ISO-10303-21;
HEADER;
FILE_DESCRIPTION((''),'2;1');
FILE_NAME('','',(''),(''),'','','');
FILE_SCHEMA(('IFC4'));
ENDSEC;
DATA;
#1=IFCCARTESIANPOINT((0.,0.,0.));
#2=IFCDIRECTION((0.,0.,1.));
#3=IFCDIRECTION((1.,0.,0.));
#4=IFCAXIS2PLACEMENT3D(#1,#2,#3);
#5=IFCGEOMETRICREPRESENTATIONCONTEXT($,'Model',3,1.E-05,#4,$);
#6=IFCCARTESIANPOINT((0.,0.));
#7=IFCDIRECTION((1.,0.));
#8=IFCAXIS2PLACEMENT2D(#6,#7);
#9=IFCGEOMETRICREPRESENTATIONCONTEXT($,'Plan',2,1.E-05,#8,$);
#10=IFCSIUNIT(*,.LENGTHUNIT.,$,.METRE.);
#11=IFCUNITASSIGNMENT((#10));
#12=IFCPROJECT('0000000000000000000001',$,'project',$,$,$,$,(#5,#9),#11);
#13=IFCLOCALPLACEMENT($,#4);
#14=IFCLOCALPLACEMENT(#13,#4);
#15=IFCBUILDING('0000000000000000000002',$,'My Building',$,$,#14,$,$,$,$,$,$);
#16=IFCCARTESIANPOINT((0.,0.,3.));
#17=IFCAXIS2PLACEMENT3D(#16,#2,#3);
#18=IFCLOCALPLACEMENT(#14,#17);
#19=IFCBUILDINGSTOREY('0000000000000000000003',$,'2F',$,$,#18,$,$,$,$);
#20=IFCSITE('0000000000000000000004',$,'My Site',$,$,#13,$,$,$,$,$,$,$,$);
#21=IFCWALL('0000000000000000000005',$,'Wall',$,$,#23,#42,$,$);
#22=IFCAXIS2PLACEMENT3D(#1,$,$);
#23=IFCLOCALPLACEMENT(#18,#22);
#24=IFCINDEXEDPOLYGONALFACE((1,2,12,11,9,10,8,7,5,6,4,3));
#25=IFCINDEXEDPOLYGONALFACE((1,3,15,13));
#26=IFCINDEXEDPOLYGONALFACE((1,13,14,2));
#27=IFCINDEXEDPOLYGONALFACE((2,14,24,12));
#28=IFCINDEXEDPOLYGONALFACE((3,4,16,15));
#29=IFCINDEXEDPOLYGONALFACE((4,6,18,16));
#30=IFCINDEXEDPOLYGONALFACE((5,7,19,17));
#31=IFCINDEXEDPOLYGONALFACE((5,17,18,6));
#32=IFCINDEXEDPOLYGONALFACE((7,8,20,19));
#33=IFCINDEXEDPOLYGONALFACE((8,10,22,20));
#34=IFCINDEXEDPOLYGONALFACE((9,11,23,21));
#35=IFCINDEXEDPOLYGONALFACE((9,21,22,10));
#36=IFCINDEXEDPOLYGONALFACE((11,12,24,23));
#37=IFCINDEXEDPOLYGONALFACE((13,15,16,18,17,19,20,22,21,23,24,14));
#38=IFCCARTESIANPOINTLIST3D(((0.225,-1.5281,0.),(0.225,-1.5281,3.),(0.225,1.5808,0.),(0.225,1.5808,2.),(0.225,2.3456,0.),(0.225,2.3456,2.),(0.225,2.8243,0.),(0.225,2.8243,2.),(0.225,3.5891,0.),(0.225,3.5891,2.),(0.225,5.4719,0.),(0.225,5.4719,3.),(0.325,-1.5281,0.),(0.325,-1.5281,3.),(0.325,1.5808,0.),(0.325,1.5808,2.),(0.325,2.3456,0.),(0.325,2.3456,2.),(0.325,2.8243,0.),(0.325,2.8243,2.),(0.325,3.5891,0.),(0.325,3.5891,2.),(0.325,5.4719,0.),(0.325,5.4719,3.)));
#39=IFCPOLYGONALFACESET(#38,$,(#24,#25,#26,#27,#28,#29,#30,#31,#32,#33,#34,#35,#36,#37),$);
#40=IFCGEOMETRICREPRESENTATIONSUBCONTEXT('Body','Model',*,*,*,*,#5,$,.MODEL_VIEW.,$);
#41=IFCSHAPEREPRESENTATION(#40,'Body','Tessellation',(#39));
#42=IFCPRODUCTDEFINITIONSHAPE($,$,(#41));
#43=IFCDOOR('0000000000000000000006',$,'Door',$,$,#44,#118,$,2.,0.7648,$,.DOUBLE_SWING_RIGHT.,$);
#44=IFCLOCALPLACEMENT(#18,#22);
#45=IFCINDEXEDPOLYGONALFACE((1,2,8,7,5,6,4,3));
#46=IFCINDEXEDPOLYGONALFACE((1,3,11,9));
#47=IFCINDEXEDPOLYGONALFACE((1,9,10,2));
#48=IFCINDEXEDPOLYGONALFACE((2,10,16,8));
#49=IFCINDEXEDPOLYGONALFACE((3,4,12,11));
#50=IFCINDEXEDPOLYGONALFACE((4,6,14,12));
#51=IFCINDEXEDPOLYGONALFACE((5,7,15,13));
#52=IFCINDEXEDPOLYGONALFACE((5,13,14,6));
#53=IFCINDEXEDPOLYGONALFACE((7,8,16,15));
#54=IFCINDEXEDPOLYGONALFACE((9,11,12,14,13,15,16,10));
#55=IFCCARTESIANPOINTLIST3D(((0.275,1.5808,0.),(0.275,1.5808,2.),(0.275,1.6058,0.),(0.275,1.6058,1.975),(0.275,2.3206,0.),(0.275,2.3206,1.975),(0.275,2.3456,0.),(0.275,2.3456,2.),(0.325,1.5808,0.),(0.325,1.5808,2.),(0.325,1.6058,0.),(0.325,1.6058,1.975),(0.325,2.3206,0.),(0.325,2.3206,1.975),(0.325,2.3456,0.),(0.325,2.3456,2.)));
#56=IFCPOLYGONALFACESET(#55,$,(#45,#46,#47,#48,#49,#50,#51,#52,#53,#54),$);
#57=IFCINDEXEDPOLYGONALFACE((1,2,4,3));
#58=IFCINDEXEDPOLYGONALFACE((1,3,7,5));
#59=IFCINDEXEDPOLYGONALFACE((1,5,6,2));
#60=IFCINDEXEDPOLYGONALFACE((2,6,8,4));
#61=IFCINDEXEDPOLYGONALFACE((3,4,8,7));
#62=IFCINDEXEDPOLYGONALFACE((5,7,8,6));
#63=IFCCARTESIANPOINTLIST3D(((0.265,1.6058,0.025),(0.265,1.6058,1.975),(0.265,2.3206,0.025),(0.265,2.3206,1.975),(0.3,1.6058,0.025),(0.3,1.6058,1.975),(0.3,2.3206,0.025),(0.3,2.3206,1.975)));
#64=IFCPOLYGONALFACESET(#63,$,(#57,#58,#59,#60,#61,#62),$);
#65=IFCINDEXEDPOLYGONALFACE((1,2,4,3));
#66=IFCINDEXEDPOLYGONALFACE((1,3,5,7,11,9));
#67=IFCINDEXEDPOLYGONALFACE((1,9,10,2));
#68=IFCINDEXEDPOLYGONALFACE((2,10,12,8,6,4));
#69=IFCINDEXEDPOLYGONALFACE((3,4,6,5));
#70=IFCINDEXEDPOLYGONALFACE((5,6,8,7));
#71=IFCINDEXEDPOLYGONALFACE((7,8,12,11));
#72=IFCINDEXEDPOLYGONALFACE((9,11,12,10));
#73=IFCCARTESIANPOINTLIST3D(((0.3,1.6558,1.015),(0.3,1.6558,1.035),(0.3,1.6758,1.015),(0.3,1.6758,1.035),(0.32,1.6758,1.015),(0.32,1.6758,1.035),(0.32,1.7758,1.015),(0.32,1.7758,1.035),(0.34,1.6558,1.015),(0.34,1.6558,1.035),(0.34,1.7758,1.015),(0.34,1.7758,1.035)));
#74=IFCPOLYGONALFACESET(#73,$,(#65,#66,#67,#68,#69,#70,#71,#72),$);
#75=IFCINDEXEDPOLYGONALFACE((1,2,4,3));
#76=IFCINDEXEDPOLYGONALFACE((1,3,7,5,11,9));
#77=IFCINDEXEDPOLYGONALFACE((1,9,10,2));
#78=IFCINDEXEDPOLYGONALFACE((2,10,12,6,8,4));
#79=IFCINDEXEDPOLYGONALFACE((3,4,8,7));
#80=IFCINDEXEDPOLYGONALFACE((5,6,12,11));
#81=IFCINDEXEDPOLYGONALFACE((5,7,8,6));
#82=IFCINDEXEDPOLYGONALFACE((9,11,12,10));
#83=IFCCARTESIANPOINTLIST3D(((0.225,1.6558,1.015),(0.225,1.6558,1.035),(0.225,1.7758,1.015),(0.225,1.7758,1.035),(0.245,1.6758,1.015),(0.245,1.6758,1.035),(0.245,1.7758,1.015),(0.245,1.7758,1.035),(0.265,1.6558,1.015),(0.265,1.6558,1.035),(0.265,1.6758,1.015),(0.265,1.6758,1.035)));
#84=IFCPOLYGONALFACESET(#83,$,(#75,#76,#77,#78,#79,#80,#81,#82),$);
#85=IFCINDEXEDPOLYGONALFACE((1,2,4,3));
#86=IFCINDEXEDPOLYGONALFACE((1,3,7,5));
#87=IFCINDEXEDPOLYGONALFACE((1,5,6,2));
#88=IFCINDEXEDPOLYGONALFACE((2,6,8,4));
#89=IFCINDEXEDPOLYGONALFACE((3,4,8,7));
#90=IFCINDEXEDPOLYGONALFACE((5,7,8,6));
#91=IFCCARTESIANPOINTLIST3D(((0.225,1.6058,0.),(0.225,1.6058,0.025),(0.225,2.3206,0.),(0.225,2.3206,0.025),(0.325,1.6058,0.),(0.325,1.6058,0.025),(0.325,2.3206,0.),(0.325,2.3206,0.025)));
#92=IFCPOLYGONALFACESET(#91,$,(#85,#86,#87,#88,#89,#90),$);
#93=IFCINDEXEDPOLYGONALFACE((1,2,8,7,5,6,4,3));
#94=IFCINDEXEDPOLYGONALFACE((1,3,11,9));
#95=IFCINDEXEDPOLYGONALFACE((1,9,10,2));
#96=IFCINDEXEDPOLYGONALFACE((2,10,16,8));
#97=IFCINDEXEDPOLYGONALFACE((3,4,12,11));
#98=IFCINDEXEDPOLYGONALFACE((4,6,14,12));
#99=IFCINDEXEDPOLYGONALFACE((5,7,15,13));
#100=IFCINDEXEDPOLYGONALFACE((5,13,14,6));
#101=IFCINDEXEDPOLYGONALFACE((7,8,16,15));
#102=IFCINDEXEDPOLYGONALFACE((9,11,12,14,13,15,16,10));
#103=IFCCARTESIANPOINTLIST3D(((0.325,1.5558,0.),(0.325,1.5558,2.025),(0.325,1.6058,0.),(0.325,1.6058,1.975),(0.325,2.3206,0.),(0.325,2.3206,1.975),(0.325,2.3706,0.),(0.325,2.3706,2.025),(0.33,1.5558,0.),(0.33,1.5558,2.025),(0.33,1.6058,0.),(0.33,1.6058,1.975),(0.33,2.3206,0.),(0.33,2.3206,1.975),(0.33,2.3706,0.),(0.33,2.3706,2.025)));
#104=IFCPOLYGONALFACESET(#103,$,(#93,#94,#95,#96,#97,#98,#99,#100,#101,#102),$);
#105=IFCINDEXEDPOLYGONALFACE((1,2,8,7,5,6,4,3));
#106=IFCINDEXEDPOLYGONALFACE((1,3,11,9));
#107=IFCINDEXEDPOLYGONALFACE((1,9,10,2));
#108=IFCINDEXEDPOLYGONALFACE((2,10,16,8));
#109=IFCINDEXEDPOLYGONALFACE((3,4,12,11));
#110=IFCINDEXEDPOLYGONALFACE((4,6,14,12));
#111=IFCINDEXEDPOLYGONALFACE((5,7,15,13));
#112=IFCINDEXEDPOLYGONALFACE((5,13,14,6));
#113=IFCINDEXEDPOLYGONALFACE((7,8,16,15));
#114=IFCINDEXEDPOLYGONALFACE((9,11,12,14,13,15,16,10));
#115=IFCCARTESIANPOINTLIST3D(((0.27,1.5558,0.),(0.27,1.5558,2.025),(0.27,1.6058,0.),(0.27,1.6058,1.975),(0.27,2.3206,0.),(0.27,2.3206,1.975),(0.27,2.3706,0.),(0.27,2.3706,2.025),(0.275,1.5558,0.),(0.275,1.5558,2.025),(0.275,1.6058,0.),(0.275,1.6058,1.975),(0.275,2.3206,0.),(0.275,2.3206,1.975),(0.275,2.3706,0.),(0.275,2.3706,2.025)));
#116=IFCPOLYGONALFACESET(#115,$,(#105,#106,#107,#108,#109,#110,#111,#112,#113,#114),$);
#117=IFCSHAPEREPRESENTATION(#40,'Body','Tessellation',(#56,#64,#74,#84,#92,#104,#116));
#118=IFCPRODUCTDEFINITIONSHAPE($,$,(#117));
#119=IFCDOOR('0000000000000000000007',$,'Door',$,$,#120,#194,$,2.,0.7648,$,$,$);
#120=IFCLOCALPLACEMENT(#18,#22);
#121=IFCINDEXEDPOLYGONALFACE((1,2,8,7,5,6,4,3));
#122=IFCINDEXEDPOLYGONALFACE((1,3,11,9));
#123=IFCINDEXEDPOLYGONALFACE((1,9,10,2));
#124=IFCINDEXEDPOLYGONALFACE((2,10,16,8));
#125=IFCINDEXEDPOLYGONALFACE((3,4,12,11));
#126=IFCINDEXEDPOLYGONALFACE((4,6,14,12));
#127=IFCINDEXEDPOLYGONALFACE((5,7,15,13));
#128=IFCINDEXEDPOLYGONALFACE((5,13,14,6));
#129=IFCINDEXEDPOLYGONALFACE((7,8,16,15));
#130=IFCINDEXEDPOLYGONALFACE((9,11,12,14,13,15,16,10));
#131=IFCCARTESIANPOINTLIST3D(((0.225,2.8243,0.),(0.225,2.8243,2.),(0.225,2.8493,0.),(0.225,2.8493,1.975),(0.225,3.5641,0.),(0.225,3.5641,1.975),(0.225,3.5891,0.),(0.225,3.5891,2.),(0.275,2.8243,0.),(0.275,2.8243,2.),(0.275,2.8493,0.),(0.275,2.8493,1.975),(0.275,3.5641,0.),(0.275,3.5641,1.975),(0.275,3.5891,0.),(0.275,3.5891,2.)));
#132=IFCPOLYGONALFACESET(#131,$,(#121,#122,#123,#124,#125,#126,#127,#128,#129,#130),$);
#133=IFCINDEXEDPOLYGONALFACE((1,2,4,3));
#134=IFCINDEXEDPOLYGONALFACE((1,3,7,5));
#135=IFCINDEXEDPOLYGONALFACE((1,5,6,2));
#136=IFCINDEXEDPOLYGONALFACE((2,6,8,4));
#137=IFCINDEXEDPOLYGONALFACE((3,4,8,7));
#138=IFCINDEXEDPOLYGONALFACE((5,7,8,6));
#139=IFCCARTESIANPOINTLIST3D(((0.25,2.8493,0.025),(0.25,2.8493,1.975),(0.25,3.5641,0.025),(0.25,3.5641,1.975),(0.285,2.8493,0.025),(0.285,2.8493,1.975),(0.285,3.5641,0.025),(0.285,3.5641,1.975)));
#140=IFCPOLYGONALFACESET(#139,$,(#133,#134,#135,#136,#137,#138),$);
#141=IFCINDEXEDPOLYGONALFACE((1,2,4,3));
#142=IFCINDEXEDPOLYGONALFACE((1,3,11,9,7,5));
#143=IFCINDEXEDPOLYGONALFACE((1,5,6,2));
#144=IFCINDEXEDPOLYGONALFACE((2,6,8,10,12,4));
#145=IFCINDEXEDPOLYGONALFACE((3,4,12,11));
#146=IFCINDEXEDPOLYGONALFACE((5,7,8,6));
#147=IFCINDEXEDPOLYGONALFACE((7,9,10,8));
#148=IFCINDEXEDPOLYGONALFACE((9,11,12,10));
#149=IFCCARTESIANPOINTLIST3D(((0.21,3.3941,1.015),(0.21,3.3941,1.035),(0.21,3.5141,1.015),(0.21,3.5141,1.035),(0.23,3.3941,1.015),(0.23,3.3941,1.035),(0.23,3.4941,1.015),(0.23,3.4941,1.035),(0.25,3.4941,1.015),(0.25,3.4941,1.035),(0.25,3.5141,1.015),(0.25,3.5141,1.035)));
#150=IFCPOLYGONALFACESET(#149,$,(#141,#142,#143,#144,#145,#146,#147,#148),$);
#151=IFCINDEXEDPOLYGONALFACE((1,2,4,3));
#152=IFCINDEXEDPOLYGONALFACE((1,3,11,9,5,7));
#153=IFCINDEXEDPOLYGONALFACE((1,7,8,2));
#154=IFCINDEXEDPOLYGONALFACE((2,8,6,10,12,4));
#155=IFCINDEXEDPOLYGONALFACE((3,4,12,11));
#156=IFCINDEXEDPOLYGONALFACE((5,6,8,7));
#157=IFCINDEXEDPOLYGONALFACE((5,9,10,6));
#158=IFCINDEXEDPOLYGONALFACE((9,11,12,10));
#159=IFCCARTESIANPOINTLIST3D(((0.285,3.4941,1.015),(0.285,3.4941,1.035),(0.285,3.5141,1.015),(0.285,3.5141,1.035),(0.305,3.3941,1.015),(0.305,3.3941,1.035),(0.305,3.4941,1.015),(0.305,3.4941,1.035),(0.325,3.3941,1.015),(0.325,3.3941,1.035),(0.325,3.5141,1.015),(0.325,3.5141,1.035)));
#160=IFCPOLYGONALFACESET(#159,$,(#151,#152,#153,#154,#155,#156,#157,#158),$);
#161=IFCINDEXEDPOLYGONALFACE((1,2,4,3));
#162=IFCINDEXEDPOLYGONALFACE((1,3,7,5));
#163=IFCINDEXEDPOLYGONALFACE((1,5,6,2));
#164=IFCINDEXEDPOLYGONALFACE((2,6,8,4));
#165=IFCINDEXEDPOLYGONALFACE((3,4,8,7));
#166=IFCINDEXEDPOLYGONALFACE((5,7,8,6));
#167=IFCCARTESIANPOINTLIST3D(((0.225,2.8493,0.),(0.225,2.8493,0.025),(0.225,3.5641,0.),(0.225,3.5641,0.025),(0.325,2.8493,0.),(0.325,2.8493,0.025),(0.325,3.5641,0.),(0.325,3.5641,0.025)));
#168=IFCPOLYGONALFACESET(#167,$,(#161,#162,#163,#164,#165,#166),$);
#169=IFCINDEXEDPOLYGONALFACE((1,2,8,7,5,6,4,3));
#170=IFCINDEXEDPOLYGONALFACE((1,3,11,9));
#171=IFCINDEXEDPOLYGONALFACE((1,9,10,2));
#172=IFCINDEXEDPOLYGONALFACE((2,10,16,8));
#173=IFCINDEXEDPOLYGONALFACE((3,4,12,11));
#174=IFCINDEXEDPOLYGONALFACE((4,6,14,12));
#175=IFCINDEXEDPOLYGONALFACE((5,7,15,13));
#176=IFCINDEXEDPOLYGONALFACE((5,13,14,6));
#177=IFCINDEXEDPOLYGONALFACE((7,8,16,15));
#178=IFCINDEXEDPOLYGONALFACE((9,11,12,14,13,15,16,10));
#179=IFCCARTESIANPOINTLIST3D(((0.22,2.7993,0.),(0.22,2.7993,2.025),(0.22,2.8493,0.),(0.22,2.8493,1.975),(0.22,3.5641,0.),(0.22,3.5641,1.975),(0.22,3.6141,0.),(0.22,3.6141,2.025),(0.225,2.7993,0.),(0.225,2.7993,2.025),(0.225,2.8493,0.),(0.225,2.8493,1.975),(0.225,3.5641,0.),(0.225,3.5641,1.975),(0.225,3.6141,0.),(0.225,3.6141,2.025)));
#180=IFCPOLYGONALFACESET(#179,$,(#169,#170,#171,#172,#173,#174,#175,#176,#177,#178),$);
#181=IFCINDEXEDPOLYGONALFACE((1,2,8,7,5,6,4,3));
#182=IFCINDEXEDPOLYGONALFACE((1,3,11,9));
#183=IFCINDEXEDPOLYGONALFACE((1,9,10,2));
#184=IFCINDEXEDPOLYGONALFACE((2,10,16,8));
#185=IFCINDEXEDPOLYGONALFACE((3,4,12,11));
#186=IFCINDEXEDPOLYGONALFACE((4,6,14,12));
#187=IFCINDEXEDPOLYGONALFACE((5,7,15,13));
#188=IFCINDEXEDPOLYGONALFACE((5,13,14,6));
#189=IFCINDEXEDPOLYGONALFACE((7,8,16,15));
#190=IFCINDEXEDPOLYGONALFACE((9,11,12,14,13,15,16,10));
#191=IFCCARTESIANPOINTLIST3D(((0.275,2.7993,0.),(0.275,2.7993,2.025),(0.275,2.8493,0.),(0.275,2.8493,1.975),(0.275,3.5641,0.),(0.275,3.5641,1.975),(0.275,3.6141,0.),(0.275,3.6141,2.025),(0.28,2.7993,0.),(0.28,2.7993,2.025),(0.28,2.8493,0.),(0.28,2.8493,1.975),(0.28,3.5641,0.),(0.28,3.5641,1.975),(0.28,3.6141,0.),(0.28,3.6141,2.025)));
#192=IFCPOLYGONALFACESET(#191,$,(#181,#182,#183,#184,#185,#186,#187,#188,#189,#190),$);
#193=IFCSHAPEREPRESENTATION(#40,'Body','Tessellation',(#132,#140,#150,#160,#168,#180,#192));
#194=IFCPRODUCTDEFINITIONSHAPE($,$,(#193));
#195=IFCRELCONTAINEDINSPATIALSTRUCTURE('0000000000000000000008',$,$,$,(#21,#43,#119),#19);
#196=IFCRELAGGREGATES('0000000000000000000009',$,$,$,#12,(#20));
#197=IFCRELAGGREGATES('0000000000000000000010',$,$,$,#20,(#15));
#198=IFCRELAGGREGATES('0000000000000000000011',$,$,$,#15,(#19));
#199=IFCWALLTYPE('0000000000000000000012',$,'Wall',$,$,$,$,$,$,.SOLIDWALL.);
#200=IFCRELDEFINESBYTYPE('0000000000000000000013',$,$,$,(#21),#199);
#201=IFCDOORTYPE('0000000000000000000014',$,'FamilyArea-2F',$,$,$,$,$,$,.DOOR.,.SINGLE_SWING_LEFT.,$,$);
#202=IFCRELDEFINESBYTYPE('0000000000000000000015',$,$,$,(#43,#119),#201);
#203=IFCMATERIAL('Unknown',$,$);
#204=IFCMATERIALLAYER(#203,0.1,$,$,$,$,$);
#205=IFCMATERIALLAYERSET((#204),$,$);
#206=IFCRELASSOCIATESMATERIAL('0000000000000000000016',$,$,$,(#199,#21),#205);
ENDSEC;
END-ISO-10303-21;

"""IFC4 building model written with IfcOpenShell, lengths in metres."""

from ifc_helpers import new_model, entity, si_unit, frame, origin_with_axes, origin_2d_with_axis, place, context, subcontext, project, spatial, line, indexed_curve, outline, extrude, shape, source, transform, mapped, material, layer, layer_set, layer_usage, type_object, type_shapes, element, fill, save


model = new_model("IFC4")

# Units and contexts
model_context = context("Model", 3, precision=1e-05, world=origin_with_axes())
plan_context = context("Plan", 2, precision=1e-05, world=origin_2d_with_axis())
body_context_1 = subcontext(model_context, "Body", "Model", "MODEL_VIEW")
body_context_2 = subcontext(plan_context, "Body", "Plan", "PLAN_VIEW")
ifc_project = project(units=[si_unit("LENGTHUNIT", "METRE")], contexts=[model_context, plan_context])

# Site, building, storey
site_placement = place(None, origin_with_axes())
site = spatial("IfcSite", under=ifc_project, at=site_placement, Name="My Site")
building_placement = place(site_placement, origin_with_axes())
building = spatial("IfcBuilding", under=site, at=building_placement, Name="My Building")
storey_placement = place(building_placement, frame((0.0, 0.0, 3.0), z_axis=(0.0, 0.0, 1.0), x_axis=(1.0, 0.0, 0.0)))
storey = spatial("IfcBuildingStorey", under=building, at=storey_placement, Name="2F")

# Shared definitions
ifc_material = material(Name="Unknown")

# Shared definitions
ifc_layer = layer(ifc_material, 0.1)
ifc_layer_set = layer_set([ifc_layer])
wall_type = type_object("IfcWallType", Name="Wall", PredefinedType="SOLIDWALL", material=ifc_layer_set)

# Wall, openings, doors
ifc_layer_usage_1 = layer_usage(ifc_layer_set, "AXIS2", "POSITIVE", 0.0)
wall_1_placement = place(storey_placement, frame((0.225, 5.4719, 0.0), z_axis=(0.0, 0.0, 1.0), x_axis=(0.000001, -1.0, 0.0)))
wall_1 = element("IfcWall", 1, at=wall_1_placement, inside=storey, type_object=wall_type, material=ifc_layer_usage_1, Name="Wall", context=body_context_1, shape_type="SweptSolid", body=[
    extrude(outline(indexed_curve([(0.0, 0.0), (0.0, 0.1), (7.0, 0.1), (7.0, 0.0)], segments=[line(1, 2, 3, 4, 1)])), origin_with_axes(), (0.0, 0.0, 1.0), 3.0),
])
shared_shape_1 = source(origin_with_axes(), body_context_1, "Body", "SweptSolid", [
    extrude(outline(indexed_curve([(0.0, 0.0), (0.7648, 0.0), (0.7648, 2.0), (0.0, 2.0)], segments=[line(1, 2, 3, 4, 1)])), frame((0.0, -0.6, 0.0), z_axis=(0.0, -1.0, 0.0), x_axis=(1.0, 0.0, 0.0)), (0.0, 0.0, -1.0), 1.2),
])
opening_1_placement = place(wall_1_placement, frame((3.8911, 0.1, 0.0), z_axis=(0.0, 0.0, 1.0), x_axis=(-1.0, 0.0, 0.0)))
opening_1 = element("IfcOpeningElement", 2, at=opening_1_placement, cuts=wall_1, PredefinedType="OPENING", context=body_context_1, shape_type="MappedRepresentation", body=[
    mapped(shared_shape_1, transform((0.0, 0.0, 0.0), x_axis=(1.0, 0.0, 0.0), y_axis=(0.0, 1.0, 0.0), z_axis=(0.0, 0.0, 1.0), scale=1.0)),
])
opening_2_placement = place(wall_1_placement, frame((1.8828, 0.0, 0.0), z_axis=(0.0, 0.0, 1.0), x_axis=(1.0, 0.0, 0.0)))
opening_2 = element("IfcOpeningElement", 3, at=opening_2_placement, cuts=wall_1, PredefinedType="OPENING", context=body_context_1, shape_type="MappedRepresentation", body=[
    mapped(shared_shape_1, transform((0.0, 0.0, 0.0), x_axis=(1.0, 0.0, 0.0), y_axis=(0.0, 1.0, 0.0), z_axis=(0.0, 0.0, 1.0), scale=1.0)),
])
door_type_1 = type_object("IfcDoorType", Name="FamilyArea-2F", OperationType="SINGLE_SWING_LEFT", PredefinedType="DOOR")
shared_shape_2 = source(origin_with_axes(), body_context_1, "Body", "SweptSolid", [
    extrude(outline(indexed_curve([(0.0, 0.0), (0.0, 2.0), (0.7648, 2.0), (0.7648, 0.0), (0.7398, 0.0), (0.7398, 1.975), (0.025, 1.975), (0.025, 0.0)], segments=[line(1, 2, 3, 4, 5, 6, 7, 8, 1)])), frame((0.0, 0.0, 0.0), z_axis=(0.0, -1.0, 0.0), x_axis=(1.0, 0.0, 0.0)), (0.0, 0.0, -1.0), 0.05),
    extrude(outline(indexed_curve([(0.0, 0.0), (0.7148, 0.0), (0.7148, 0.035), (0.0, 0.035)], segments=[line(1, 2, 3, 4, 1)])), frame((0.025, 0.025, 0.025), z_axis=(0.0, 0.0, 1.0), x_axis=(1.0, 0.0, 0.0)), (0.0, 0.0, 1.0), 1.95),
    extrude(outline(indexed_curve([(0.0, 0.0), (0.0, -0.04), (0.12, -0.04), (0.12, -0.02), (0.02, -0.02), (0.02, 0.0)], segments=[line(1, 2, 3, 4, 5, 6, 1)])), frame((0.075, 0.025, 1.015), z_axis=(0.0, 0.0, 1.0), x_axis=(1.0, 0.0, 0.0)), (0.0, 0.0, 1.0), 0.02),
    extrude(outline(indexed_curve([(0.0, 0.0), (0.0, 0.04), (0.12, 0.04), (0.12, 0.02), (0.02, 0.02), (0.02, 0.0)], segments=[line(1, 2, 3, 4, 5, 6, 1)])), frame((0.075, 0.06, 1.015), z_axis=(0.0, 0.0, 1.0), x_axis=(1.0, 0.0, 0.0)), (0.0, 0.0, 1.0), 0.02),
    extrude(outline(indexed_curve([(0.0, 0.0), (0.7148, 0.0), (0.7148, 0.1), (0.0, 0.1)], segments=[line(1, 2, 3, 4, 1)])), frame((0.025, 0.0, 0.0), z_axis=(0.0, 0.0, 1.0), x_axis=(1.0, 0.0, 0.0)), (0.0, 0.0, 1.0), 0.025),
    extrude(outline(indexed_curve([(0.0, 0.0), (0.0, 2.025), (0.8148, 2.025), (0.8148, 0.0), (0.7648, 0.0), (0.7648, 1.975), (0.05, 1.975), (0.05, 0.0)], segments=[line(1, 2, 3, 4, 5, 6, 7, 8, 1)])), frame((-0.025, -0.005, 0.0), z_axis=(0.0, -1.0, 0.0), x_axis=(1.0, 0.0, 0.0)), (0.0, 0.0, -1.0), 0.005),
    extrude(outline(indexed_curve([(0.0, 0.0), (0.0, 2.025), (0.8148, 2.025), (0.8148, 0.0), (0.7648, 0.0), (0.7648, 1.975), (0.05, 1.975), (0.05, 0.0)], segments=[line(1, 2, 3, 4, 5, 6, 7, 8, 1)])), frame((-0.025, 0.05, 0.0), z_axis=(0.0, -1.0, 0.0), x_axis=(1.0, 0.0, 0.0)), (0.0, 0.0, -1.0), 0.005),
])
shared_shape_3 = source(origin_with_axes(), body_context_2, "Body", "Curve2D", [
    entity("IfcIndexedPolyCurve", entity("IfcCartesianPointList2D", [[0.0, 0.0], [0.025, 0.0], [0.025, 0.05], [0.0, 0.05]]), [entity("IfcLineIndex", [1, 2, 3, 4, 1])]),
    entity("IfcIndexedPolyCurve", entity("IfcCartesianPointList2D", [[0.7648, 0.0], [0.7398, 0.0], [0.7398, 0.05], [0.7648, 0.05]]), [entity("IfcLineIndex", [1, 2, 3, 4, 1])]),
    entity("IfcIndexedPolyCurve", entity("IfcCartesianPointList2D", [[0.7398, 0.05], [0.7398, -0.6648], [0.7048, -0.6648]])),
    entity("IfcTrimmedCurve", entity("IfcEllipse", entity("IfcAxis2Placement2D", entity("IfcCartesianPoint", [0.7048, 0.05]), entity("IfcDirection", [1.0, 0.0])), 0.6798, 0.7148), [entity("IfcCartesianPoint", [0.7048, 0.7648])], [entity("IfcCartesianPoint", [0.7048, -0.6648])], True, "CARTESIAN"),
    entity("IfcIndexedPolyCurve", entity("IfcCartesianPointList2D", [[0.7398, 0.05], [0.7048, 0.05], [0.7048, 0.7648], [0.7398, 0.7648]]), [entity("IfcLineIndex", [1, 2, 3, 4, 1])]),
])
type_shapes(door_type_1, [shared_shape_2, shared_shape_3])
door_1_placement = place(opening_1_placement, frame((0.0, 0.0, 0.0), z_axis=(0.0, 0.0, 1.0), x_axis=(1.0, 0.0, 0.0)))
door_1 = element("IfcDoor", 4, at=door_1_placement, inside=storey, type_object=door_type_1, Name="Door", OperationType="DOUBLE_SWING_RIGHT", OverallHeight=2.0, OverallWidth=0.7648, shapes=[
    shape(body_context_1, "Body", "MappedRepresentation", [mapped(shared_shape_2, transform((0.0, 0.0, 0.0), x_axis=(1.0, 0.0, 0.0), y_axis=(0.0, 1.0, 0.0), z_axis=(0.0, 0.0, 1.0), scale=1.0))]),
    shape(body_context_2, "Body", "MappedRepresentation", [mapped(shared_shape_3, transform((0.0, 0.0, 0.0), x_axis=(1.0, 0.0, 0.0), y_axis=(0.0, 1.0, 0.0), z_axis=(0.0, 0.0, 1.0), scale=1.0))]),
])
fill(opening_1, door_1)
door_2_placement = place(opening_2_placement, frame((0.0, 0.0, 0.0), z_axis=(0.0, 0.0, 1.0), x_axis=(1.0, 0.0, 0.0)))
door_2 = element("IfcDoor", 5, at=door_2_placement, inside=storey, type_object=door_type_1, Name="Door", OverallHeight=2.0, OverallWidth=0.7648, shapes=[
    shape(body_context_1, "Body", "MappedRepresentation", [mapped(shared_shape_2, transform((0.0, 0.0, 0.0), x_axis=(1.0, 0.0, 0.0), y_axis=(0.0, 1.0, 0.0), z_axis=(0.0, 0.0, 1.0), scale=1.0))]),
    shape(body_context_2, "Body", "MappedRepresentation", [mapped(shared_shape_3, transform((0.0, 0.0, 0.0), x_axis=(1.0, 0.0, 0.0), y_axis=(0.0, 1.0, 0.0), z_axis=(0.0, 0.0, 1.0), scale=1.0))]),
])
fill(opening_2, door_2)

save(model, "model.ifc")
